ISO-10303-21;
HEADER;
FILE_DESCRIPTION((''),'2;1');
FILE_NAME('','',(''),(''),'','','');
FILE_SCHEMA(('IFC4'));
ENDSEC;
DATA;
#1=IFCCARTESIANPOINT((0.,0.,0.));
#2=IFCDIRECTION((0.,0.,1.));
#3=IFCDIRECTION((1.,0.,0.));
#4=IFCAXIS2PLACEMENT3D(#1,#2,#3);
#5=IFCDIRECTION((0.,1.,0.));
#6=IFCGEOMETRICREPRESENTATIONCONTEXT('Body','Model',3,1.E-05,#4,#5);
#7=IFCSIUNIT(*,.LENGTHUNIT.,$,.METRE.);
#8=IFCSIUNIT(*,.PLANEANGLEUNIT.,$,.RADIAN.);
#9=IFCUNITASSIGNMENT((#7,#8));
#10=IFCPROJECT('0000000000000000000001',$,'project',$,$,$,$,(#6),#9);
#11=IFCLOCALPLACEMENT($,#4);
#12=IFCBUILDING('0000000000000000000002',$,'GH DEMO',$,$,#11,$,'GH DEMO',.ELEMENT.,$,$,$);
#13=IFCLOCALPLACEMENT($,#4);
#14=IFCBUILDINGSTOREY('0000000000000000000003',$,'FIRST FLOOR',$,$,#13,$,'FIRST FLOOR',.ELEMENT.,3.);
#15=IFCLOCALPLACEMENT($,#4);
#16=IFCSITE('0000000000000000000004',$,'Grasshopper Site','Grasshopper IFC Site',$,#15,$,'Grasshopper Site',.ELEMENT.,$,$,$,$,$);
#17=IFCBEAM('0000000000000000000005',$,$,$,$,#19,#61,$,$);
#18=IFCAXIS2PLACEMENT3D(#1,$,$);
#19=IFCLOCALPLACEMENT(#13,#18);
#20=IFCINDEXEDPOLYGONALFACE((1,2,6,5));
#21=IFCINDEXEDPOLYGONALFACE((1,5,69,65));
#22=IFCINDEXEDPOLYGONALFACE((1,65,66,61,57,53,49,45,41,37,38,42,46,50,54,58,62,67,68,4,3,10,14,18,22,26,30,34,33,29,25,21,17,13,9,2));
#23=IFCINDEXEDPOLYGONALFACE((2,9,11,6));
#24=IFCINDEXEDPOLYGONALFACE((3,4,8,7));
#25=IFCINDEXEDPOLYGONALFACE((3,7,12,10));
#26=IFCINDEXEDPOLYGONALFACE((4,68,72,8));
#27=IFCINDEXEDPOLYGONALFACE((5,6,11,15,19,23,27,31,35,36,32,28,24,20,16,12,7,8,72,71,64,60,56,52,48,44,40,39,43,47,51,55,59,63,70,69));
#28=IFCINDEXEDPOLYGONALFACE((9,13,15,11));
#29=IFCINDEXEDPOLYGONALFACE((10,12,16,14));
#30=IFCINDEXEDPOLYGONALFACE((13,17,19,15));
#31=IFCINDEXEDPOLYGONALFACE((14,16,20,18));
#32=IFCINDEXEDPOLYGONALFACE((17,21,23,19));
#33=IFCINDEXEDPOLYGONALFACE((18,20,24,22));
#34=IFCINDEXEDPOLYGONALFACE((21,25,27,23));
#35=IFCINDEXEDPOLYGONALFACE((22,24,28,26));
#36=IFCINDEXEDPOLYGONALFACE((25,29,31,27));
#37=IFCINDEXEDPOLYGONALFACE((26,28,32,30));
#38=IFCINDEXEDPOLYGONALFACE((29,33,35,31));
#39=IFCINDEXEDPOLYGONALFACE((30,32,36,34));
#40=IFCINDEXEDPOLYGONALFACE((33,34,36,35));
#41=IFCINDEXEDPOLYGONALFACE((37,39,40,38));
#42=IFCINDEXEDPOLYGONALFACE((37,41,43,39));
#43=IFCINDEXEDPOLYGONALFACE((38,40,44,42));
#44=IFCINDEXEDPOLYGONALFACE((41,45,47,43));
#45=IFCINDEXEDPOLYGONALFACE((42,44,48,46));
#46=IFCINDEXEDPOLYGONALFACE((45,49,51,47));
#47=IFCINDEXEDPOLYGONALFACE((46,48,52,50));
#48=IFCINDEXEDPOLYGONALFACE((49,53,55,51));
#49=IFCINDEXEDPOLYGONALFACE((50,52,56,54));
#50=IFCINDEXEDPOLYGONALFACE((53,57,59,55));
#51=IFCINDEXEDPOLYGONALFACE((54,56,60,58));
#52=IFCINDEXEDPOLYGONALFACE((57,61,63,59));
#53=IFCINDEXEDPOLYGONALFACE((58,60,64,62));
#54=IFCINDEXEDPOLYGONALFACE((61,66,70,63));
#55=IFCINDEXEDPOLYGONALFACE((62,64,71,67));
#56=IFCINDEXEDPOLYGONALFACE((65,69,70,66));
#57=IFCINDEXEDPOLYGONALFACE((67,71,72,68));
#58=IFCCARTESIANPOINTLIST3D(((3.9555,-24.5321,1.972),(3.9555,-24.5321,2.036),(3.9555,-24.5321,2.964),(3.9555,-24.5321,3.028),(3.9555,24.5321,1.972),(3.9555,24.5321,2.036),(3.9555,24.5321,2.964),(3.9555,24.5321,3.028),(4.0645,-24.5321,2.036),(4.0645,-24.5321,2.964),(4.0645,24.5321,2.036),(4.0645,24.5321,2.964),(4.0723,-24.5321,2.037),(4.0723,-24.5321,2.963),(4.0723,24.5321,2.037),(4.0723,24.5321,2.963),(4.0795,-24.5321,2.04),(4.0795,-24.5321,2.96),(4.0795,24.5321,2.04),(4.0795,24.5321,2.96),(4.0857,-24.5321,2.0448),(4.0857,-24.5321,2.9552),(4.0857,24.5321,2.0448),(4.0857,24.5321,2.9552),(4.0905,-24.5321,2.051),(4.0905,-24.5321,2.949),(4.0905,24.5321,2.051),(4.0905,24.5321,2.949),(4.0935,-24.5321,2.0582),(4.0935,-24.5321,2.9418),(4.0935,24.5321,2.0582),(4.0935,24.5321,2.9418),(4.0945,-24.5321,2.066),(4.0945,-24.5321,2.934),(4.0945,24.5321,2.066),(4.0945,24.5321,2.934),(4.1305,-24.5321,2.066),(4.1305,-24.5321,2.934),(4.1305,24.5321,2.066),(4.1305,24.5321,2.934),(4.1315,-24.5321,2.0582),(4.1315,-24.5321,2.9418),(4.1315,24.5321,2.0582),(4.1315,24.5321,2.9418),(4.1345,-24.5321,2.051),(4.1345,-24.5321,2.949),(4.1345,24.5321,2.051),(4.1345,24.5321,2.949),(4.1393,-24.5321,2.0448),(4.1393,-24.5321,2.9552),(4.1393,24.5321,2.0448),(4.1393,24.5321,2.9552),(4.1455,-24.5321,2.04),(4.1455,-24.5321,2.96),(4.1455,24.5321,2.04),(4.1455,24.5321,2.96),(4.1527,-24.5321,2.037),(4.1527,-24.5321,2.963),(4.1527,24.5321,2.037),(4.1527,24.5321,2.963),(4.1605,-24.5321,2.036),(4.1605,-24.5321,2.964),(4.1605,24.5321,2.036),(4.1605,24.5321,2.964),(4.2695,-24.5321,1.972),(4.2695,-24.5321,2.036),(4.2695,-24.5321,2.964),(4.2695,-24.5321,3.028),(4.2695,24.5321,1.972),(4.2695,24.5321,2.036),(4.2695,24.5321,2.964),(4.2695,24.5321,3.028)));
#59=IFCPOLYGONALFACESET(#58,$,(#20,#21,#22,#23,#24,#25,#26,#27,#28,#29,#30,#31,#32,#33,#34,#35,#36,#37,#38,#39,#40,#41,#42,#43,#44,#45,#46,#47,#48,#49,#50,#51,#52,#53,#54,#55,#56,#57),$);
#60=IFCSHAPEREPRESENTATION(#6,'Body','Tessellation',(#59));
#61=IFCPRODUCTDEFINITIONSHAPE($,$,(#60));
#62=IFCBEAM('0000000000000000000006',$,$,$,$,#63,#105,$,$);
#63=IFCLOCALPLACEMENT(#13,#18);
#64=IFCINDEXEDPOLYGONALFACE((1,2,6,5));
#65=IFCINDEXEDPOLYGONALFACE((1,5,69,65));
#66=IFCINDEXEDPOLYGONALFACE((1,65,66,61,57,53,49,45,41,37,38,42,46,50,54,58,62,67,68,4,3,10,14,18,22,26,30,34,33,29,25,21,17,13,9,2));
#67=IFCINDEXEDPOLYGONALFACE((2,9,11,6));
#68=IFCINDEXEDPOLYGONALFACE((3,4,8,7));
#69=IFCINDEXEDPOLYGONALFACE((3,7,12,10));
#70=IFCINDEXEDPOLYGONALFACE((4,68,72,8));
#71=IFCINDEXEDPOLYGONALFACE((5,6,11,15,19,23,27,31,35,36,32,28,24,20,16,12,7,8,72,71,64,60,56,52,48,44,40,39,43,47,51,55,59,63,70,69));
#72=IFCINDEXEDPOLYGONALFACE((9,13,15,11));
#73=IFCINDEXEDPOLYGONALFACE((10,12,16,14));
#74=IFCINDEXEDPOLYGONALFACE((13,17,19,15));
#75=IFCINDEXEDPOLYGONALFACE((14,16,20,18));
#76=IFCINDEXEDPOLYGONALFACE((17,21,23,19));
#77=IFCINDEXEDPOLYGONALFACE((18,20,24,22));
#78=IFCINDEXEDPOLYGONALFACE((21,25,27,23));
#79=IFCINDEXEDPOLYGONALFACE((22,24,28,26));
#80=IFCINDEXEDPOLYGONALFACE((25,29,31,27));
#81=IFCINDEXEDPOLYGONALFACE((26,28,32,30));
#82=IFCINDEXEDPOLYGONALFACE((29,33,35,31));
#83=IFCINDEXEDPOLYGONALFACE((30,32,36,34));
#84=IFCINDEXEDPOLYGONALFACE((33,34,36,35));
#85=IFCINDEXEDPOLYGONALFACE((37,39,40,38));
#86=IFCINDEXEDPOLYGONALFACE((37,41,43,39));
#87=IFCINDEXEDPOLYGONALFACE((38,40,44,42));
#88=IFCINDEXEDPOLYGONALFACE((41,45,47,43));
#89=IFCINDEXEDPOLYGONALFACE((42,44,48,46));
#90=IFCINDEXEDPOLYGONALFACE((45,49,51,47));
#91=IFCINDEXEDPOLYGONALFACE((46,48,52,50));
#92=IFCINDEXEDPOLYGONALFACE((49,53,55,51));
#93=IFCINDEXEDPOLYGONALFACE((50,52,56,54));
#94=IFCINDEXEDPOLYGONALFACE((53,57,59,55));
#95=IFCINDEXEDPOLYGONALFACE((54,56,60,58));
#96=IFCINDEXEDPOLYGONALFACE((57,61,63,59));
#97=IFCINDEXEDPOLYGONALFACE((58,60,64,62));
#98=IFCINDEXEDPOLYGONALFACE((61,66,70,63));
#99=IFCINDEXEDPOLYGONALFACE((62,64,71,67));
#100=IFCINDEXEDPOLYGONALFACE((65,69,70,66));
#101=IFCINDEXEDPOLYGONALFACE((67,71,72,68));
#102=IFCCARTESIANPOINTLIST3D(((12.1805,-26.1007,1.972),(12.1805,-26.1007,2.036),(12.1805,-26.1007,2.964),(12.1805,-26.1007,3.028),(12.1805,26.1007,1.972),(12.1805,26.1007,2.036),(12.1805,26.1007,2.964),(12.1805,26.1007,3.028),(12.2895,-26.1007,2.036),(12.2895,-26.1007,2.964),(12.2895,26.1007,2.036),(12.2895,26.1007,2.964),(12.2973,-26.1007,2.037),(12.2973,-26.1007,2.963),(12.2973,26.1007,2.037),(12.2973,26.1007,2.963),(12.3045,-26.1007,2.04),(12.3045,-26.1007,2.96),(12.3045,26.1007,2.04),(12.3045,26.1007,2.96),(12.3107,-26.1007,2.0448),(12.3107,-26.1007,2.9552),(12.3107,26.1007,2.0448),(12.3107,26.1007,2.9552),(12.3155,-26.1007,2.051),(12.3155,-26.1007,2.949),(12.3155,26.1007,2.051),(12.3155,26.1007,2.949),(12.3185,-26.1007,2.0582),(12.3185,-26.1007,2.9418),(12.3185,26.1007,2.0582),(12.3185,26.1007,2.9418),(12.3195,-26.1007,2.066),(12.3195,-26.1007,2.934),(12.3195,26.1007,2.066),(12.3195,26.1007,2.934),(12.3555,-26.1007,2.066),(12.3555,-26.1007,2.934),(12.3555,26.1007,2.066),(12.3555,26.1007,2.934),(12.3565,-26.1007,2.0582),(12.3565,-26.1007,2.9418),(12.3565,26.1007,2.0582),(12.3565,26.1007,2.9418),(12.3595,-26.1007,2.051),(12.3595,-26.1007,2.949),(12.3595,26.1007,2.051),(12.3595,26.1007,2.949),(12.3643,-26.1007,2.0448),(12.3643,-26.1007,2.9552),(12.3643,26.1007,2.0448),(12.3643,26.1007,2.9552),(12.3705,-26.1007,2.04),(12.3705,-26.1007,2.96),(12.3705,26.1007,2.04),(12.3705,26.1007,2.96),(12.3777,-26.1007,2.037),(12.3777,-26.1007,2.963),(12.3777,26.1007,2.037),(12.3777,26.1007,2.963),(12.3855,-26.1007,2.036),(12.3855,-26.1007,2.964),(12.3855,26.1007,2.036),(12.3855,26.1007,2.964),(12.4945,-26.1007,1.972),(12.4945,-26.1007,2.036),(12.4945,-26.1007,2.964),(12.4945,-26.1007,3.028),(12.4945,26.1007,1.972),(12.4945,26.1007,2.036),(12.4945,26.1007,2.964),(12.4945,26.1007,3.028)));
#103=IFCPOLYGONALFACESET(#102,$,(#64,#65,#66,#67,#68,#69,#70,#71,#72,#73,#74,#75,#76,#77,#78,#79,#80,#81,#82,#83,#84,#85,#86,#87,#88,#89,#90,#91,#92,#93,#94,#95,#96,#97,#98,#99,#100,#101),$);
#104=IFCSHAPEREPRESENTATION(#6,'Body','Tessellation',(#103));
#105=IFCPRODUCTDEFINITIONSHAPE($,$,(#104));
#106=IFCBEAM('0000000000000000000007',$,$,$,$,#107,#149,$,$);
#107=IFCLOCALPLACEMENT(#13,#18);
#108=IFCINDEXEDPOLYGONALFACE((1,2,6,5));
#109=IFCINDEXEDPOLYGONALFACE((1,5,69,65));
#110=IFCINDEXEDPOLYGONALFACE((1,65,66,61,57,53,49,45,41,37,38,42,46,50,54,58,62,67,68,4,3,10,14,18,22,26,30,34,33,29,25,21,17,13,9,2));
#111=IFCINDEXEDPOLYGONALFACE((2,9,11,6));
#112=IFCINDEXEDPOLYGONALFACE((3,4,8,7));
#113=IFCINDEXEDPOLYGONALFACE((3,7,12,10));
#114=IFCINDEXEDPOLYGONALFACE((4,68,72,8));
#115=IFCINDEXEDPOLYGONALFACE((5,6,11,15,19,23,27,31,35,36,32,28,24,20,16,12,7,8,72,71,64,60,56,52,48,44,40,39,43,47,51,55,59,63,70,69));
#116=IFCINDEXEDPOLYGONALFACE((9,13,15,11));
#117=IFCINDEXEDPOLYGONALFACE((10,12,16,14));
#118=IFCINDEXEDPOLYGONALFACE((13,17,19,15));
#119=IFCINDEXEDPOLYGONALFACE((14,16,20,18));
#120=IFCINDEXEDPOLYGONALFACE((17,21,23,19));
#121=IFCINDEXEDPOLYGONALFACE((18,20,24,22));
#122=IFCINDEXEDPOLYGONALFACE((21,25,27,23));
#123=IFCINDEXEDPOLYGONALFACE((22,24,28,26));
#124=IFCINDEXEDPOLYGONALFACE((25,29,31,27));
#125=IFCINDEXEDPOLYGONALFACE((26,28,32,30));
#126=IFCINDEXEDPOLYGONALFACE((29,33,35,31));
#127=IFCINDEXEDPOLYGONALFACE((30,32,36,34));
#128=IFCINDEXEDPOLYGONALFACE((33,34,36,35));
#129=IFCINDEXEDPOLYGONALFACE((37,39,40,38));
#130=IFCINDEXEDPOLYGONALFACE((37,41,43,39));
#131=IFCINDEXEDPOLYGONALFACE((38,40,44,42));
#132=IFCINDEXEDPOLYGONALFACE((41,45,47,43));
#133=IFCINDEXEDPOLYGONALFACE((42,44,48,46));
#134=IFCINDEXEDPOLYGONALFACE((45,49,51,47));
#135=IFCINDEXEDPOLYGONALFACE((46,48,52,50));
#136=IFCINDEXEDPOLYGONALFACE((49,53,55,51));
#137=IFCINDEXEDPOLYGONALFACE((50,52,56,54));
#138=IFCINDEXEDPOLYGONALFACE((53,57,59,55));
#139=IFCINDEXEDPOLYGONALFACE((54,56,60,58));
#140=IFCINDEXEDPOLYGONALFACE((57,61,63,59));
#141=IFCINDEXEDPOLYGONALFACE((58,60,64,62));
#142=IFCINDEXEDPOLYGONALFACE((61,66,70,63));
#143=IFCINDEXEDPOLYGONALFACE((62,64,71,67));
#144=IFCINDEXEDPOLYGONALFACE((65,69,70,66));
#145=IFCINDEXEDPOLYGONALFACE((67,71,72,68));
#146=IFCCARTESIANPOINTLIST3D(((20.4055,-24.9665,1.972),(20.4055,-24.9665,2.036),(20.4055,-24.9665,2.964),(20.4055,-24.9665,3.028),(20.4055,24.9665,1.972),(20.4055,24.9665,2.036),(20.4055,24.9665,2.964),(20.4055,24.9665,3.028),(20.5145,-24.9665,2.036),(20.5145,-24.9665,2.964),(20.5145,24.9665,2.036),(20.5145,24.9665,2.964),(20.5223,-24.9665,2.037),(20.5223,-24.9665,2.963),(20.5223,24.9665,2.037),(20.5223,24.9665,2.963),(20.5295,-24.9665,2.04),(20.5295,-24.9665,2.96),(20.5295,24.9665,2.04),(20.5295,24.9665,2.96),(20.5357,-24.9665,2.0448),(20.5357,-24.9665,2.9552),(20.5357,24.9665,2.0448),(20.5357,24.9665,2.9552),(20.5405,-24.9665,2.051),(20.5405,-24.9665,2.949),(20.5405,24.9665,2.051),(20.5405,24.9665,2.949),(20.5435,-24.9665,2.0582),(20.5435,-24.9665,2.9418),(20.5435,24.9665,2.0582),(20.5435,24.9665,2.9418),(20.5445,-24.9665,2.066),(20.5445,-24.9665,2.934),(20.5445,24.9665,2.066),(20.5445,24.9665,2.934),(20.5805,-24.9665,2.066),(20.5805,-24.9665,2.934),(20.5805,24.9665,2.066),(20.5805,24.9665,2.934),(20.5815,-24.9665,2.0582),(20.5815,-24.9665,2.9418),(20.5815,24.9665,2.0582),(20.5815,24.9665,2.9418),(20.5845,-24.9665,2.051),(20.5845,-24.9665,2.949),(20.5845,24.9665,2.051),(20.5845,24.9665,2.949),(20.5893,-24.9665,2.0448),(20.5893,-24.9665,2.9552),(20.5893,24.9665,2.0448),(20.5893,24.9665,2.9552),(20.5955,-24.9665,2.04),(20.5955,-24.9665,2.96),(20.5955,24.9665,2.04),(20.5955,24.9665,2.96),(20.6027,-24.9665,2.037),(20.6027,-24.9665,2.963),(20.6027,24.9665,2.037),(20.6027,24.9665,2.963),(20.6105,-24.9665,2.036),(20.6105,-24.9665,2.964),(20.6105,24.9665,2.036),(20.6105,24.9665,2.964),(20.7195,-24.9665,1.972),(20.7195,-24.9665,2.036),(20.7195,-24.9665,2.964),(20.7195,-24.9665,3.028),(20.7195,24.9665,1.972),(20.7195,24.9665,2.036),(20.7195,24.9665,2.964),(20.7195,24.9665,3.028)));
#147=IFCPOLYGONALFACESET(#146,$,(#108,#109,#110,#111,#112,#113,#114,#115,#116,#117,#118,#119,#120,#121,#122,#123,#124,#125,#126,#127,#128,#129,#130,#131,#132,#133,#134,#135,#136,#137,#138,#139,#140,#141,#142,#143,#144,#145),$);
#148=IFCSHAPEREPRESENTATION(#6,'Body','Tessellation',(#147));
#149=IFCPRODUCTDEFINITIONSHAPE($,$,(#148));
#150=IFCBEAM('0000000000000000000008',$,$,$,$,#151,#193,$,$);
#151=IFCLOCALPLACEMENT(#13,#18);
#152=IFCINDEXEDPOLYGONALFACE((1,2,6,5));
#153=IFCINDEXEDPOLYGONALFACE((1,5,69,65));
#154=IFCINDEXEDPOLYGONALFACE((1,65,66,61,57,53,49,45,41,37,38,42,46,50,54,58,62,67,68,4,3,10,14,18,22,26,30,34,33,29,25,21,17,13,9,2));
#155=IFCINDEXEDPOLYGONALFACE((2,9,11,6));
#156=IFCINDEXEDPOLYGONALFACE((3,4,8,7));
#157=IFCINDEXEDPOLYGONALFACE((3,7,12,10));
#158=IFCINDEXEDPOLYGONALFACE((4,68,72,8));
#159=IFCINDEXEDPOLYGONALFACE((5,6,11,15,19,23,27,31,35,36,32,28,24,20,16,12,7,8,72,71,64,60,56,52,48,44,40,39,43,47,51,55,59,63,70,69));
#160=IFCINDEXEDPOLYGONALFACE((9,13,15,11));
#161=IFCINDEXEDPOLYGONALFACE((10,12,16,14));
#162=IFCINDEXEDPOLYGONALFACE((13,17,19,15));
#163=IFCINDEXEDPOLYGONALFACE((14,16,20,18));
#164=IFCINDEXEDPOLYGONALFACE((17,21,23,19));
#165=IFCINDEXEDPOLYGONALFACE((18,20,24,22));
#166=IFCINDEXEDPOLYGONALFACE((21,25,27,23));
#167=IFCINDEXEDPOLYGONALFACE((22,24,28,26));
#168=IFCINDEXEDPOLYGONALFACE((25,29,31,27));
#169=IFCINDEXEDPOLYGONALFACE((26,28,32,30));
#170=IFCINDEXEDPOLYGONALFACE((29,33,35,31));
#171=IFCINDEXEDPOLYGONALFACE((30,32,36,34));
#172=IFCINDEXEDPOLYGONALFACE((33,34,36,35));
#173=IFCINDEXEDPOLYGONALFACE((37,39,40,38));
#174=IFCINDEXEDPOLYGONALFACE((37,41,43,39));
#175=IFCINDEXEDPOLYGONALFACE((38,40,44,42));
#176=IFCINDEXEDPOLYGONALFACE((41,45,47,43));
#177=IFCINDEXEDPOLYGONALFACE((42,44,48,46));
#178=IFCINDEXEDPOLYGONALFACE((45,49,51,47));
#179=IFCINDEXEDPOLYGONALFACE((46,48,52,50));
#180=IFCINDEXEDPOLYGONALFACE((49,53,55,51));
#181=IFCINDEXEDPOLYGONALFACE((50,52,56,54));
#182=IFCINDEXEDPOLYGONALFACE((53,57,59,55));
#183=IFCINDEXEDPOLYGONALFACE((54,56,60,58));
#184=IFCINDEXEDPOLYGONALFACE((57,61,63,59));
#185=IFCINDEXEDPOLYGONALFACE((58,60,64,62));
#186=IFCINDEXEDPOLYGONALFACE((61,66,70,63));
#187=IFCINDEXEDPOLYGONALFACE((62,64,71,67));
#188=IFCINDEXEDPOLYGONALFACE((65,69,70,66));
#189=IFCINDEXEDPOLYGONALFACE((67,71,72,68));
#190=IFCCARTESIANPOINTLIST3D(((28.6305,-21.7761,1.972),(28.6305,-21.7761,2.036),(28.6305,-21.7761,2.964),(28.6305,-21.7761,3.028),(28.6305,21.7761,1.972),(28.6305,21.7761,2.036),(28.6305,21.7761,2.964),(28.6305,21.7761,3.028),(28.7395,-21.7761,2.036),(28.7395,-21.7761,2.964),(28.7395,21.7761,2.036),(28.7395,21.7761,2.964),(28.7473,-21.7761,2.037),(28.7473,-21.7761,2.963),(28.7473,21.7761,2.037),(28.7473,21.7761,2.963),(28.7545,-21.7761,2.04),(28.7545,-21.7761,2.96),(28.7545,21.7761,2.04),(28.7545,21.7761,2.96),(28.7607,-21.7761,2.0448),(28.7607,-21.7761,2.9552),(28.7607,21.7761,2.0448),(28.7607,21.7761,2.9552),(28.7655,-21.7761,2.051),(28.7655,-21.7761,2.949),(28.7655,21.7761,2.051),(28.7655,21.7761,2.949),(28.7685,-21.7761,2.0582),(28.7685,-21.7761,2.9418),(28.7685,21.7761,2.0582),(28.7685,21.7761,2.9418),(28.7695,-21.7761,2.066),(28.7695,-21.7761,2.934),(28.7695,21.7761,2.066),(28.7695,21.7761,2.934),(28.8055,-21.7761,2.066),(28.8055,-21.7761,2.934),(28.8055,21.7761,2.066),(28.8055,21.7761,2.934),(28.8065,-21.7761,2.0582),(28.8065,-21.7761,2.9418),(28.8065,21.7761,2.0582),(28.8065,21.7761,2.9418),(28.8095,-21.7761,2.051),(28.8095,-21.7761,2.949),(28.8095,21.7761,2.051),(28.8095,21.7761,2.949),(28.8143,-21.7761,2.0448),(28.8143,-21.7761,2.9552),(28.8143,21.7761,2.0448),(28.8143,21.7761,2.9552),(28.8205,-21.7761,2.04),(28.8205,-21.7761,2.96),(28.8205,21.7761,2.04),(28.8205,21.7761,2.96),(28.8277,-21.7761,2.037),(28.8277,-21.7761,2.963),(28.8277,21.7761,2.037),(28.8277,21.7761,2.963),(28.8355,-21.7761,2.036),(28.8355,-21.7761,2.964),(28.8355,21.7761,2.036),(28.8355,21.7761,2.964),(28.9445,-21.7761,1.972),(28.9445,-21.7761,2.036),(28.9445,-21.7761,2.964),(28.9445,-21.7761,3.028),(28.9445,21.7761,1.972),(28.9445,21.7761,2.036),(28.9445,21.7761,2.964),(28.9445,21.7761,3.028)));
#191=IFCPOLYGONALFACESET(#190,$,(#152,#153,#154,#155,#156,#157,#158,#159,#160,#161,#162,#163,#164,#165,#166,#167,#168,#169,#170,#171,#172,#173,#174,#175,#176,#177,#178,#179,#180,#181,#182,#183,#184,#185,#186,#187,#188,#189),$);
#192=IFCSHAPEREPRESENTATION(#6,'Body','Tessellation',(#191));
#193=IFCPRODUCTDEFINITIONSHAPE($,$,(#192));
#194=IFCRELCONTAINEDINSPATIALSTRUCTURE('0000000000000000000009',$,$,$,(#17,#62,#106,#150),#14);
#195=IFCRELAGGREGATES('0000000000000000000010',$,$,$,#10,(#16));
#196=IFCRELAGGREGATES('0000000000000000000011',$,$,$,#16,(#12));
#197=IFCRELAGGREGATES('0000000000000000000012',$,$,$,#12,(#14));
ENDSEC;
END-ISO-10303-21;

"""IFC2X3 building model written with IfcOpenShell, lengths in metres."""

from ifc_helpers import new_model, si_unit, direction, frame, origin_with_axes, origin_2d, place, context, project, spatial, i_section, extrude, element, save


model = new_model("IFC2X3")

# Units and contexts
model_context = context("Model", 3, precision=1e-05, world=origin_with_axes(), true_north=direction((0.0, 1.0, 0.0)), identifier="Body")
ifc_project = project(units=[si_unit("LENGTHUNIT", "METRE"), si_unit("PLANEANGLEUNIT", "RADIAN")], contexts=[model_context])

# Site, building, storey
site_placement = place(None, origin_with_axes())
site = spatial("IfcSite", under=ifc_project, at=site_placement, Name="Grasshopper Site", Description="Grasshopper IFC Site", LongName="Grasshopper Site", CompositionType="ELEMENT")
building_placement = place(None, origin_with_axes())
building = spatial("IfcBuilding", under=site, at=building_placement, Name="GH DEMO", LongName="GH DEMO", CompositionType="ELEMENT")
storey_placement = place(None, origin_with_axes())
storey = spatial("IfcBuildingStorey", under=building, at=storey_placement, Name="FIRST FLOOR", LongName="FIRST FLOOR", CompositionType="ELEMENT", Elevation=3.0)

# Beams
beam_1_placement = place(None, origin_with_axes())
element("IfcBeam", 1, at=beam_1_placement, inside=storey, context=model_context, shape_type="SweptSolid", body=[
    extrude(i_section(OverallWidth=0.314, OverallDepth=1.056, WebThickness=0.036, FlangeThickness=0.064, FilletRadius=0.03, at=origin_2d()), frame((4.1125, -24.5321, 2.5), z_axis=(0.0, 1.0, 0.0), x_axis=(-1.0, 0.0, 0.0)), (0.0, 0.0, 1.0), 49.0642),
])
beam_2_placement = place(None, origin_with_axes())
element("IfcBeam", 2, at=beam_2_placement, inside=storey, context=model_context, shape_type="SweptSolid", body=[
    extrude(i_section(OverallWidth=0.314, OverallDepth=1.056, WebThickness=0.036, FlangeThickness=0.064, FilletRadius=0.03, at=origin_2d()), frame((12.3375, -26.1007, 2.5), z_axis=(0.0, 1.0, 0.0), x_axis=(-1.0, 0.0, 0.0)), (0.0, 0.0, 1.0), 52.2014),
])
beam_3_placement = place(None, origin_with_axes())
element("IfcBeam", 3, at=beam_3_placement, inside=storey, context=model_context, shape_type="SweptSolid", body=[
    extrude(i_section(OverallWidth=0.314, OverallDepth=1.056, WebThickness=0.036, FlangeThickness=0.064, FilletRadius=0.03, at=origin_2d()), frame((20.5625, -24.9665, 2.5), z_axis=(0.0, 1.0, 0.0), x_axis=(-1.0, 0.0, 0.0)), (0.0, 0.0, 1.0), 49.933),
])
beam_4_placement = place(None, origin_with_axes())
element("IfcBeam", 4, at=beam_4_placement, inside=storey, context=model_context, shape_type="SweptSolid", body=[
    extrude(i_section(OverallWidth=0.314, OverallDepth=1.056, WebThickness=0.036, FlangeThickness=0.064, FilletRadius=0.03, at=origin_2d()), frame((28.7875, -21.7761, 2.5), z_axis=(0.0, 1.0, 0.0), x_axis=(-1.0, 0.0, 0.0)), (0.0, 0.0, 1.0), 43.5521),
])

save(model, "model.ifc")
